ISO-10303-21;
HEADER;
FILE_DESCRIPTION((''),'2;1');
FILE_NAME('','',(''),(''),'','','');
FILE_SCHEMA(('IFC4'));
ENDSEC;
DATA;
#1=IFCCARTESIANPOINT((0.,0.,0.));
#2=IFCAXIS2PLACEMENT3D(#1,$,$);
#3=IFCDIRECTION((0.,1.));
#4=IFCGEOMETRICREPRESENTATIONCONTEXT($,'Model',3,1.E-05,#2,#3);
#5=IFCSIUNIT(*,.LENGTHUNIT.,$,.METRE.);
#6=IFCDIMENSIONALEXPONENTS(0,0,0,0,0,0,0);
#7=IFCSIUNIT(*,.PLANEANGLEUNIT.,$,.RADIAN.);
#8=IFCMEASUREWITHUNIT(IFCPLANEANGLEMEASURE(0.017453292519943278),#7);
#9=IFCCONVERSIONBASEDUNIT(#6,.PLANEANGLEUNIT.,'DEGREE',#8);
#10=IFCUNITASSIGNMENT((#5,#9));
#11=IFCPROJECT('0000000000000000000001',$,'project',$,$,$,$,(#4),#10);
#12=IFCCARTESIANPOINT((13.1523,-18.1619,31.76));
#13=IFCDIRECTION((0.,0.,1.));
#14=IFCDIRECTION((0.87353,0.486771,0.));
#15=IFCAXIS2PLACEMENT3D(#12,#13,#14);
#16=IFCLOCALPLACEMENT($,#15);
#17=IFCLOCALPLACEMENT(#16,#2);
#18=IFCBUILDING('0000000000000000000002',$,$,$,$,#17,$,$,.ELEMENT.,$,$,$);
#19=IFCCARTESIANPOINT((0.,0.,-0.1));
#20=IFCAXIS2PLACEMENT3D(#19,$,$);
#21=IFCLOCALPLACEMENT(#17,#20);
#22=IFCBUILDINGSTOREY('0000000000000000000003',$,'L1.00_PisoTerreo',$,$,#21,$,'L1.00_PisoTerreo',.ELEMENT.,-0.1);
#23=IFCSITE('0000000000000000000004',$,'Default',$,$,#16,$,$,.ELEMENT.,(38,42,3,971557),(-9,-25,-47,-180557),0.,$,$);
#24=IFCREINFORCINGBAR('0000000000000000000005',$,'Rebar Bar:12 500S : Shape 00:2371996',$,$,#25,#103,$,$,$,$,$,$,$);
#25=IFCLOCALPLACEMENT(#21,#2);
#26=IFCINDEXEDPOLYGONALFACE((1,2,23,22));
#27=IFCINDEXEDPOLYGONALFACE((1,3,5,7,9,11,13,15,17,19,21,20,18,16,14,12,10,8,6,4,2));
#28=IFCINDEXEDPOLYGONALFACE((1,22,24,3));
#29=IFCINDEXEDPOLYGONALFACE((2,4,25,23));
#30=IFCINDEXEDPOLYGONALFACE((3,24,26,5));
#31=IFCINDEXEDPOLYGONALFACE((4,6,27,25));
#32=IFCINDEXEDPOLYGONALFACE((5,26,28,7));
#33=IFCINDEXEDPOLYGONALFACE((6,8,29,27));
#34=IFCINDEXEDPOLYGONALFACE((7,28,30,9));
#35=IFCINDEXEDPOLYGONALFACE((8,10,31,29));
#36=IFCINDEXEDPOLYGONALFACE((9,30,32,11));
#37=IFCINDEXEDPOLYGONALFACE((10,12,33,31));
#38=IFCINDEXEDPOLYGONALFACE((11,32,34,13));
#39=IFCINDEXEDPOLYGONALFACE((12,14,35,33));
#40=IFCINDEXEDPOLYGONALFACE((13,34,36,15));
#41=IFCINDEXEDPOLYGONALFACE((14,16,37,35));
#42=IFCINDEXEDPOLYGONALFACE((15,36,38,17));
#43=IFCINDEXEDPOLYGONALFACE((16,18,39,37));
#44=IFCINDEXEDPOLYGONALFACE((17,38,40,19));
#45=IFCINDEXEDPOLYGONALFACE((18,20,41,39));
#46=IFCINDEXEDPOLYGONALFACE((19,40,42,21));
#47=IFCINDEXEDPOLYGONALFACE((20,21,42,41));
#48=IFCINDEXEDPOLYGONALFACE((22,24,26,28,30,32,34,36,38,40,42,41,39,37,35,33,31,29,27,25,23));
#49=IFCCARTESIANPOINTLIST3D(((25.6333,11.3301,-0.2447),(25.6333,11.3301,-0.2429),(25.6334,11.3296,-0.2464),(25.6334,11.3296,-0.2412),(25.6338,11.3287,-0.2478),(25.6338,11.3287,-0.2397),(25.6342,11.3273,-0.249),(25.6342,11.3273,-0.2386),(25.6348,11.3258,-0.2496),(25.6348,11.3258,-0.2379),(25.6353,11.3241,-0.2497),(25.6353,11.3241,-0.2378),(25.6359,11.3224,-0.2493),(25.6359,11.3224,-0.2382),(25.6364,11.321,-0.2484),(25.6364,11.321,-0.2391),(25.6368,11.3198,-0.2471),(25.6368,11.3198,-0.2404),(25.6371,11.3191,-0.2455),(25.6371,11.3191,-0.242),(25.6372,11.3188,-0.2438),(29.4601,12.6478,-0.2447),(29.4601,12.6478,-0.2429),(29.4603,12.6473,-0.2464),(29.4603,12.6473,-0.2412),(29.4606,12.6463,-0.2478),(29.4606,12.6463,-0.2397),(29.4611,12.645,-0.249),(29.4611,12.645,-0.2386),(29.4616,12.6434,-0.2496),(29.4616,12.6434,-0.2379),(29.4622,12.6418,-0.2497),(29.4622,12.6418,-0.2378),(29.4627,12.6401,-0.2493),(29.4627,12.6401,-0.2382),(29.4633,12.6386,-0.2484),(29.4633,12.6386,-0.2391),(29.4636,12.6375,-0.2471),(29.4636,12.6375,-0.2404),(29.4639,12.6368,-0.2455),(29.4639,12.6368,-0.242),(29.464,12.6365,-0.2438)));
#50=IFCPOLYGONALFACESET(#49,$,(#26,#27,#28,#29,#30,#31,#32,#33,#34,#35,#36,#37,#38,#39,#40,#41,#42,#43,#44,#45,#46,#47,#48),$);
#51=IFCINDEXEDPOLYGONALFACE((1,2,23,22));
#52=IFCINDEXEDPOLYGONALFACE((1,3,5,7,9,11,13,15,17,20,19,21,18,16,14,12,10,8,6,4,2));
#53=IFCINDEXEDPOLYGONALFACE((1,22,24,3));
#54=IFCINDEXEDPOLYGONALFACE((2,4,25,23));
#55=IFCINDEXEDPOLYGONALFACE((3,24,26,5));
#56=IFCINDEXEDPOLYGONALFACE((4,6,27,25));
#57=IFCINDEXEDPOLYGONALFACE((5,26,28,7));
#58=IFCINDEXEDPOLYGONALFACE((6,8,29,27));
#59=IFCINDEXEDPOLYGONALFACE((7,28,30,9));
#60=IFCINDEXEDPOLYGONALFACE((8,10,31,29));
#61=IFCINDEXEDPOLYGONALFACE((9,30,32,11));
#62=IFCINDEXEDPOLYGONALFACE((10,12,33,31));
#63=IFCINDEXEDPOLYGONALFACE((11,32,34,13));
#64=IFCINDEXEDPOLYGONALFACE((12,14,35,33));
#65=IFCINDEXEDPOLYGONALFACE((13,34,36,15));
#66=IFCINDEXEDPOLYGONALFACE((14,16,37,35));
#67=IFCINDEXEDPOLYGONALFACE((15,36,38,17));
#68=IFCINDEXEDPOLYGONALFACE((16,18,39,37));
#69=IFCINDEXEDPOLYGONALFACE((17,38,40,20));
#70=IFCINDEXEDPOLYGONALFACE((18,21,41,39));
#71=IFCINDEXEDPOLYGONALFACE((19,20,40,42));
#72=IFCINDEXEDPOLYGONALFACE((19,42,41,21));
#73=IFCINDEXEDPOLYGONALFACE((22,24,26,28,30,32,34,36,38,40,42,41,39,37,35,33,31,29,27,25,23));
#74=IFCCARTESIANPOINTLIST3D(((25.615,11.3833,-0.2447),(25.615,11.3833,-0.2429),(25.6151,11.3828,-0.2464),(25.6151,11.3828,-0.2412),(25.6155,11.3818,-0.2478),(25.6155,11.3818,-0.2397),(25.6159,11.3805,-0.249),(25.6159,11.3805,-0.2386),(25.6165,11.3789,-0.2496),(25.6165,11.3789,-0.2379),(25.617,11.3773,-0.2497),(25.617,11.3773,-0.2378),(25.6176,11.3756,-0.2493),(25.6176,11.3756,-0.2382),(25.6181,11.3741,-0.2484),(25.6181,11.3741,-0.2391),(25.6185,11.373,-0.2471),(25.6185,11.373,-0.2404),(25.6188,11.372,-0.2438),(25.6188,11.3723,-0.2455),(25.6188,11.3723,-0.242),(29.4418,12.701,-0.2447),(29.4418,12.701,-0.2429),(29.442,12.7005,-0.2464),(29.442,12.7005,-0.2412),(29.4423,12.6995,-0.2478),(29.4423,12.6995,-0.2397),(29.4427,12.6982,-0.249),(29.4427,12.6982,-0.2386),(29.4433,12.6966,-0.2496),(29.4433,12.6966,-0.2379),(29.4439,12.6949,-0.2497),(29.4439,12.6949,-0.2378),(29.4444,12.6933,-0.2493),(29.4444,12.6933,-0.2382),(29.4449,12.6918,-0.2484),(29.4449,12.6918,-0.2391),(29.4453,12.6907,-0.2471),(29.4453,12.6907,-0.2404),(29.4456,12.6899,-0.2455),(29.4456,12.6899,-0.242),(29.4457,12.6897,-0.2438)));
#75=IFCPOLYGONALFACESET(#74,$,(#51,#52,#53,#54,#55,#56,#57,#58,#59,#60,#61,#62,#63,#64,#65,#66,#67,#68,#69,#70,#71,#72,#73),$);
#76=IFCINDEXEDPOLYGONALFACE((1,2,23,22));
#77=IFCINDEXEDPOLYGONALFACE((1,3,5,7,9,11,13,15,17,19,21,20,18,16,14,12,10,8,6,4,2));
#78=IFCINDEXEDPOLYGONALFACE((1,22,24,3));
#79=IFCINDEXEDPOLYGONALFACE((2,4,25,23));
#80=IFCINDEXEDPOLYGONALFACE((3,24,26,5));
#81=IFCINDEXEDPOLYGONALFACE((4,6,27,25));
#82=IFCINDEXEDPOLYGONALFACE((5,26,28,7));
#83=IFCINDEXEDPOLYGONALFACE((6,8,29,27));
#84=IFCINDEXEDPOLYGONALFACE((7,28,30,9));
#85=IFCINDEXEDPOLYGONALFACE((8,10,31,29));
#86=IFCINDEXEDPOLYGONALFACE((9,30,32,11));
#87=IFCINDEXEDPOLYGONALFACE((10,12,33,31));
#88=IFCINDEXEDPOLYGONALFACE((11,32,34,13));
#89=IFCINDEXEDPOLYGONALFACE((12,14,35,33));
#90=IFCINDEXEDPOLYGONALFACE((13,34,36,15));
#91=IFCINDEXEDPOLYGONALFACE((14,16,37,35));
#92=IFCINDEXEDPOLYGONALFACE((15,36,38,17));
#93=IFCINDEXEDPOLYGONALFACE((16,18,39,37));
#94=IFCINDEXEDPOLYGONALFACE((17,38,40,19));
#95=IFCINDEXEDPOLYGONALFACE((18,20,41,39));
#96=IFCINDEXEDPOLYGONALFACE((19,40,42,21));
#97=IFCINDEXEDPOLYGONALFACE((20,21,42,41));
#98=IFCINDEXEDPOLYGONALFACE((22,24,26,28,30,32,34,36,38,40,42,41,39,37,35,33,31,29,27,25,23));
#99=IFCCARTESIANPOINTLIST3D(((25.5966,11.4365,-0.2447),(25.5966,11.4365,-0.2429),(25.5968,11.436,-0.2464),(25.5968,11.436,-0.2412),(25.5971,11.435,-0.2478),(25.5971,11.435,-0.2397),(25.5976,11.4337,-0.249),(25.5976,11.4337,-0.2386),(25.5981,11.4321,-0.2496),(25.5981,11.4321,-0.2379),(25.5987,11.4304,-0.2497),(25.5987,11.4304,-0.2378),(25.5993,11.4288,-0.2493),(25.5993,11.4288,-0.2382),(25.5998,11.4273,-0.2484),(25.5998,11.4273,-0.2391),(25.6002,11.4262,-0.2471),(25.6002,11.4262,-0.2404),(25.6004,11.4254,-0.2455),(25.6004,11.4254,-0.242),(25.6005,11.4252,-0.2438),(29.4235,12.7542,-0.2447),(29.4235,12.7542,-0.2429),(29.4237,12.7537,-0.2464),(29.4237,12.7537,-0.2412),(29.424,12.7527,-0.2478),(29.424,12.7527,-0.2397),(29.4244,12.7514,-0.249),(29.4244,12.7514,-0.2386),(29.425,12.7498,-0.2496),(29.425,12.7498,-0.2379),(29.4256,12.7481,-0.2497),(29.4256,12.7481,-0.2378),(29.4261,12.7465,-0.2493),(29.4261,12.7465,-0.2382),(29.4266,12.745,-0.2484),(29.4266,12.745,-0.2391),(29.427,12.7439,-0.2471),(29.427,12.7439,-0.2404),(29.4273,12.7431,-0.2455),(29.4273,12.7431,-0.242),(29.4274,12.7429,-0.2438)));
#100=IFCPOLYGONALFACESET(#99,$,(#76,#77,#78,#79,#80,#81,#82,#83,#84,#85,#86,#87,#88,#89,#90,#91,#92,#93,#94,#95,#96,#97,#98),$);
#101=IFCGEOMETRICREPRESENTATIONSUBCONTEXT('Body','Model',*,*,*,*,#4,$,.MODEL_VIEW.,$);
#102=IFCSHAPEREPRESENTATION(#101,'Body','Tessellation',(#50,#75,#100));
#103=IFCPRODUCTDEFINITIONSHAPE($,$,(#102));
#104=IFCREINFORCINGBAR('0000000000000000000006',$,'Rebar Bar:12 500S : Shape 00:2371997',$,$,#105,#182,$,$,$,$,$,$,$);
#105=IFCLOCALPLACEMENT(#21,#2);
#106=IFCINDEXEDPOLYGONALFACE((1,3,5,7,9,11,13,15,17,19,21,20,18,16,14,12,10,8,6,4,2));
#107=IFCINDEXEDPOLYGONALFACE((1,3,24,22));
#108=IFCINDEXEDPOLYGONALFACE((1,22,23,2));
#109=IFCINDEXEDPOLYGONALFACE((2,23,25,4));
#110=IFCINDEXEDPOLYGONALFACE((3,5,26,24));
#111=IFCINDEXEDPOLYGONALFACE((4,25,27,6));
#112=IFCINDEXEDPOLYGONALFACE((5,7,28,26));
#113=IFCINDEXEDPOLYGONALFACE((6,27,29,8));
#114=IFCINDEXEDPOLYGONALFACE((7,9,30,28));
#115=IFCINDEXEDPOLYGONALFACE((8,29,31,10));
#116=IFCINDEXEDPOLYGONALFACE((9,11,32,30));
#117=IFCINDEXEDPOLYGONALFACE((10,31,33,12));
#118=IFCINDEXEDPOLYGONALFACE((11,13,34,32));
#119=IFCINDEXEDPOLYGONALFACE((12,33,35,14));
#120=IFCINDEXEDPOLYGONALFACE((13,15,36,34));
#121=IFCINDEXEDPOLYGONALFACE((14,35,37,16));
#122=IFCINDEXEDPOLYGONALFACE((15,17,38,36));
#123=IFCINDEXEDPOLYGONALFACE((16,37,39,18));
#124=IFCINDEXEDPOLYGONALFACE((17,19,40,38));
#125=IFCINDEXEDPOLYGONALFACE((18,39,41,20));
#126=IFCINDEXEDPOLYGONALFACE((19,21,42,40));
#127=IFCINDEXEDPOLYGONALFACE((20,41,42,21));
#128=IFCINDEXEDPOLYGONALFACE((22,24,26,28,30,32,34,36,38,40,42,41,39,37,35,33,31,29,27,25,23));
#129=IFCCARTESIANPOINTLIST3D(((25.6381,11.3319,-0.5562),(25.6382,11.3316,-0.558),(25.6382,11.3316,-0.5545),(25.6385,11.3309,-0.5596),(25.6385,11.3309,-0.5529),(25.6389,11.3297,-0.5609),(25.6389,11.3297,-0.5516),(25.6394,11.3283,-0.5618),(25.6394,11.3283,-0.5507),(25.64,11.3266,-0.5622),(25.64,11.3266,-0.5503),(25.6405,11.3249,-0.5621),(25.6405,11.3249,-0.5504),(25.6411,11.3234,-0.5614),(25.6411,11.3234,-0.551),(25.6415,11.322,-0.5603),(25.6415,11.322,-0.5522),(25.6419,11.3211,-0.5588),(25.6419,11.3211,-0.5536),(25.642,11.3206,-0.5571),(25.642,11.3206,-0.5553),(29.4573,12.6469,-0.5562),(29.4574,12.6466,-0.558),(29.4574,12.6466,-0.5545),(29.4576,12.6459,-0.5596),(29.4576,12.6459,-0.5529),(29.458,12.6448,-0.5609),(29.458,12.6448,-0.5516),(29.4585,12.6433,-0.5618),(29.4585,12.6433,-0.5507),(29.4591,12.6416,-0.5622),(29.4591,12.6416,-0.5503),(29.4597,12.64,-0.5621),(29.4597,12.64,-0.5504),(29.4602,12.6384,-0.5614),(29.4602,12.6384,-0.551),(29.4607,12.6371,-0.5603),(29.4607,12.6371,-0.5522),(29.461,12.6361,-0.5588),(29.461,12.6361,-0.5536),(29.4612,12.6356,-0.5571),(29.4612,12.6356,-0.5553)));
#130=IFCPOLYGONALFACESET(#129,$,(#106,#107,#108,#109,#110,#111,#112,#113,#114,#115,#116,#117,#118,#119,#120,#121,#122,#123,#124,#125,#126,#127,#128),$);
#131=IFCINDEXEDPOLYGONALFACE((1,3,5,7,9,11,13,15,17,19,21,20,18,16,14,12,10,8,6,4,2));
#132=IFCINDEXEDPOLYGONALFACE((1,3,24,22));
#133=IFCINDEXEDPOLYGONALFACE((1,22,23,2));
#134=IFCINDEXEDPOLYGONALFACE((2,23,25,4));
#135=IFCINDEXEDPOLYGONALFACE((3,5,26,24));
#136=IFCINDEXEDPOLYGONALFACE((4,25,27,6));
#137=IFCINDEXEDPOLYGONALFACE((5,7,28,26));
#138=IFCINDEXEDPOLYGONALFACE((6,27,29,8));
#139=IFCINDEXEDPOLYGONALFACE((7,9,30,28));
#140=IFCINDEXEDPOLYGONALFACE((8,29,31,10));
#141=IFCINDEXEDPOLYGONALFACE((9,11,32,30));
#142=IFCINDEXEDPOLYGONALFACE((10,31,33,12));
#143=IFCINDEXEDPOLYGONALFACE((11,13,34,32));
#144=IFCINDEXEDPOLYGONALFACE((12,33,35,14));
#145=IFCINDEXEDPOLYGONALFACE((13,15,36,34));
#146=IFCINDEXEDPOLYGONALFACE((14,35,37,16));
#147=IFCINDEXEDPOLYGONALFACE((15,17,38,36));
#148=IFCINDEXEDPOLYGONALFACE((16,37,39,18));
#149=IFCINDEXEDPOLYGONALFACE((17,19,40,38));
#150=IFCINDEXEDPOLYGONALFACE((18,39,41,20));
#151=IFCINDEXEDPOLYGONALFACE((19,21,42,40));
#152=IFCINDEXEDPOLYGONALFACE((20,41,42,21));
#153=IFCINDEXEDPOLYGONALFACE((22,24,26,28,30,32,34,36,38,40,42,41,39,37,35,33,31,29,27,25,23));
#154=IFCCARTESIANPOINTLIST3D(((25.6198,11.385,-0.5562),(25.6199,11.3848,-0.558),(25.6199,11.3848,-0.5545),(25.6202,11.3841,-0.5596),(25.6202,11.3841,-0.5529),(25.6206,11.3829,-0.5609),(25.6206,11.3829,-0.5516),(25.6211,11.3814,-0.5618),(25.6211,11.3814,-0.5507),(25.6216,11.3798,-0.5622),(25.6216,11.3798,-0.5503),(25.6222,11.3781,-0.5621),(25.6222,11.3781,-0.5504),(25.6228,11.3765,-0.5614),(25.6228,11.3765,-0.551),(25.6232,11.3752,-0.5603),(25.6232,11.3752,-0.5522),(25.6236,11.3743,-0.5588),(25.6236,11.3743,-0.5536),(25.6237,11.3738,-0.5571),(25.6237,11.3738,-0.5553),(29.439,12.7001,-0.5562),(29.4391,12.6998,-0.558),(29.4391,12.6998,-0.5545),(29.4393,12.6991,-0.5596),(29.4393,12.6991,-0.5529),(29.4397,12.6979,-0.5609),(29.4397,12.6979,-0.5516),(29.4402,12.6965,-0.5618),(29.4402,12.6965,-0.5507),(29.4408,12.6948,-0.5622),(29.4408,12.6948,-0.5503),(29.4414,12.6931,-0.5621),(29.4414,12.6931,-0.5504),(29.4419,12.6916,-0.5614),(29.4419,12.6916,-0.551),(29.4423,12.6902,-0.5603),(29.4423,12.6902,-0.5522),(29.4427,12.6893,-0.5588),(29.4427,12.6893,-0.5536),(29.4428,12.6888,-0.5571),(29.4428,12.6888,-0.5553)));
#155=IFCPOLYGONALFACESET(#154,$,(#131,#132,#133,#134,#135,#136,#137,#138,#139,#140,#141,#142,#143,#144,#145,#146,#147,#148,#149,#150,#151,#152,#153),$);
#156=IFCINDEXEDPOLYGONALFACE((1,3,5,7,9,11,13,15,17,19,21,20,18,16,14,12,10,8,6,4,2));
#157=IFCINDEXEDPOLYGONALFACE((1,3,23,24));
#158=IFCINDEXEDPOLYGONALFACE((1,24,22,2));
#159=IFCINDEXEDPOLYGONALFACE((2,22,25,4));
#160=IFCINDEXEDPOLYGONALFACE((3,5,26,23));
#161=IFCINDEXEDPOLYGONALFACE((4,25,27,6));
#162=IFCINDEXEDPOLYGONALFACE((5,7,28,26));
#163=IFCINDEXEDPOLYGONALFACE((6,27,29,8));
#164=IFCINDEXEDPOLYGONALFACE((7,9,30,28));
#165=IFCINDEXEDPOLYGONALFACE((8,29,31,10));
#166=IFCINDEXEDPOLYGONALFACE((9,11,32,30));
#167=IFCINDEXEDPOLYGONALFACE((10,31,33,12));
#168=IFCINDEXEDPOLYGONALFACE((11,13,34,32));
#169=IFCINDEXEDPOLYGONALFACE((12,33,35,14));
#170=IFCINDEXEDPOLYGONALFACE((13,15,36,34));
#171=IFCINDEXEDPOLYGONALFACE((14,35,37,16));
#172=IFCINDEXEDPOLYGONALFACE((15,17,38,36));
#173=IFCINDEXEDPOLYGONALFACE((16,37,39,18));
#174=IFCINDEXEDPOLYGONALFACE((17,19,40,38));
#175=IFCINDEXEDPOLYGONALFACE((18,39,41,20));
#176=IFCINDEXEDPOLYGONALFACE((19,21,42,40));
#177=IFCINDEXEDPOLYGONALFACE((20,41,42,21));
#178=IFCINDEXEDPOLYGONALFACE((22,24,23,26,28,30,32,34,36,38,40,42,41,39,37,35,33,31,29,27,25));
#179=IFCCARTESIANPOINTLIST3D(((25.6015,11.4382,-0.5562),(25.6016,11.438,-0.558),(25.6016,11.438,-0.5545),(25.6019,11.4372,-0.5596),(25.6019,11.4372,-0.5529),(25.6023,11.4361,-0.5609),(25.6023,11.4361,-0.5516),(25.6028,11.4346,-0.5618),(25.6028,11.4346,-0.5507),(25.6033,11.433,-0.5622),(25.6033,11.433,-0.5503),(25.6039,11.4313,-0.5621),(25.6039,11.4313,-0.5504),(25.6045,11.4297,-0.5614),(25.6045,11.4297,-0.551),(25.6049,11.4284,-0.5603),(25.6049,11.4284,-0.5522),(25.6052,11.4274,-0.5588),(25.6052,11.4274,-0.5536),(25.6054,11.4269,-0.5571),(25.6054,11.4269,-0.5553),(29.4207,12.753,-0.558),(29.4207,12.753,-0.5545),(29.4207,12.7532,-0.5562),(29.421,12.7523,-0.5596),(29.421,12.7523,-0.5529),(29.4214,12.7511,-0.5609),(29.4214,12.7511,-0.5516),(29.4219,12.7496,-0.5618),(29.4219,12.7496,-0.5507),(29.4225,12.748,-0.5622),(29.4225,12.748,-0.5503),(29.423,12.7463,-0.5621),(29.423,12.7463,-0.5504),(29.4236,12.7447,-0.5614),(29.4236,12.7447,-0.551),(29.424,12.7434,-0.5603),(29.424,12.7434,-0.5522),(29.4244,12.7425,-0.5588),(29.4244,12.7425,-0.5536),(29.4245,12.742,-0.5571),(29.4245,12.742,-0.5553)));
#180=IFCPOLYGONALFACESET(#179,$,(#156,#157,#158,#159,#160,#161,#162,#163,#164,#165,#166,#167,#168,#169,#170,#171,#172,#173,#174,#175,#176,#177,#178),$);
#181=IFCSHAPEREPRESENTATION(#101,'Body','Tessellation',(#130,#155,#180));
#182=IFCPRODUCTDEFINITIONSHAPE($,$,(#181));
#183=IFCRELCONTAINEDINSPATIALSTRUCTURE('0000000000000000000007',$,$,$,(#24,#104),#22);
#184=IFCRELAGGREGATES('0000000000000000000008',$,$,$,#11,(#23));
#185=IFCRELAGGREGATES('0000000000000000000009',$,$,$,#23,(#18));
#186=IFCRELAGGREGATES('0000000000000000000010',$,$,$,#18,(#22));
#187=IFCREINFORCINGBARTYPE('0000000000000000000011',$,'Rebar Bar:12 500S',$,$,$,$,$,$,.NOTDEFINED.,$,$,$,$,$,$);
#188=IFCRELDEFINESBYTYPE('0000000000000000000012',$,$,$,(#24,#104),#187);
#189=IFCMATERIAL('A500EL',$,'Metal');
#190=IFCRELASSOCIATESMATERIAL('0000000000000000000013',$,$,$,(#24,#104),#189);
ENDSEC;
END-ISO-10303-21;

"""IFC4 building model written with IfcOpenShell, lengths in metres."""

from ifc_helpers import new_model, entity, si_unit, converted_unit, direction, frame, origin, place, context, subcontext, project, spatial, material, type_object, element, save


model = new_model("IFC4")

# Units and contexts
model_context = context("Model", 3, precision=1e-05, world=origin(), true_north=direction((0.0, 1.0)))
body_context = subcontext(model_context, "Body", "Model", "MODEL_VIEW")
ifc_project = project(units=[si_unit("LENGTHUNIT", "METRE"), converted_unit("PLANEANGLEUNIT", "DEGREE", entity("IfcPlaneAngleMeasure", 0.017453292519943278), si_unit("PLANEANGLEUNIT", "RADIAN"), dimensions=[0, 0, 0, 0, 0, 0, 0])], contexts=[model_context])

# Site, building, storey
site_placement = place(None, frame((13.1523, -18.1619, 31.76), z_axis=(0.0, 0.0, 1.0), x_axis=(0.87353, 0.486771, 0.0)))
site = spatial("IfcSite", under=ifc_project, at=site_placement, Name="Default", CompositionType="ELEMENT", RefLatitude=(38, 42, 3, 971557), RefLongitude=(-9, -25, -47, -180557), RefElevation=0.0)
building_placement = place(site_placement, origin())
building = spatial("IfcBuilding", under=site, at=building_placement, CompositionType="ELEMENT")
storey_placement = place(building_placement, frame((0.0, 0.0, -0.1)))
storey = spatial("IfcBuildingStorey", under=building, at=storey_placement, Name="L1.00_PisoTerreo", LongName="L1.00_PisoTerreo", CompositionType="ELEMENT", Elevation=-0.1)

# Reinforcing bars
ifc_material = material(Name="A500EL", Category="Metal")
reinforcing_bar_type_1 = type_object("IfcReinforcingBarType", Name="Rebar Bar:12 500S", PredefinedType="NOTDEFINED")
reinforcing_bar_1_placement = place(storey_placement, origin())
element("IfcReinforcingBar", 1, at=reinforcing_bar_1_placement, inside=storey, type_object=reinforcing_bar_type_1, material=ifc_material, Name="Rebar Bar:12 500S : Shape 00:2371996", context=body_context, shape_type="AdvancedSweptSolid", body=[
    entity("IfcSweptDiskSolid", entity("IfcIndexedPolyCurve", entity("IfcCartesianPointList3D", [[29.462, 12.6422, -0.2438], [25.6352, 11.3245, -0.2438]]), None, False), 0.006, None, 0.0, 1.0),
    entity("IfcSweptDiskSolid", entity("IfcIndexedPolyCurve", entity("IfcCartesianPointList3D", [[29.4437, 12.6954, -0.2438], [25.6169, 11.3777, -0.2438]]), None, False), 0.006, None, 0.0, 1.0),
    entity("IfcSweptDiskSolid", entity("IfcIndexedPolyCurve", entity("IfcCartesianPointList3D", [[29.4254, 12.7485, -0.2438], [25.5986, 11.4309, -0.2438]]), None, False), 0.006, None, 0.0, 1.0),
])
reinforcing_bar_2_placement = place(storey_placement, origin())
element("IfcReinforcingBar", 2, at=reinforcing_bar_2_placement, inside=storey, type_object=reinforcing_bar_type_1, material=ifc_material, Name="Rebar Bar:12 500S : Shape 00:2371997", context=body_context, shape_type="AdvancedSweptSolid", body=[
    entity("IfcSweptDiskSolid", entity("IfcIndexedPolyCurve", entity("IfcCartesianPointList3D", [[25.6401, 11.3262, -0.5562], [29.4592, 12.6412, -0.5562]]), None, False), 0.006, None, 0.0, 1.0),
    entity("IfcSweptDiskSolid", entity("IfcIndexedPolyCurve", entity("IfcCartesianPointList3D", [[25.6218, 11.3794, -0.5562], [29.4409, 12.6944, -0.5562]]), None, False), 0.006, None, 0.0, 1.0),
    entity("IfcSweptDiskSolid", entity("IfcIndexedPolyCurve", entity("IfcCartesianPointList3D", [[25.6035, 11.4325, -0.5562], [29.4226, 12.7476, -0.5562]]), None, False), 0.006, None, 0.0, 1.0),
])

save(model, "model.ifc")
